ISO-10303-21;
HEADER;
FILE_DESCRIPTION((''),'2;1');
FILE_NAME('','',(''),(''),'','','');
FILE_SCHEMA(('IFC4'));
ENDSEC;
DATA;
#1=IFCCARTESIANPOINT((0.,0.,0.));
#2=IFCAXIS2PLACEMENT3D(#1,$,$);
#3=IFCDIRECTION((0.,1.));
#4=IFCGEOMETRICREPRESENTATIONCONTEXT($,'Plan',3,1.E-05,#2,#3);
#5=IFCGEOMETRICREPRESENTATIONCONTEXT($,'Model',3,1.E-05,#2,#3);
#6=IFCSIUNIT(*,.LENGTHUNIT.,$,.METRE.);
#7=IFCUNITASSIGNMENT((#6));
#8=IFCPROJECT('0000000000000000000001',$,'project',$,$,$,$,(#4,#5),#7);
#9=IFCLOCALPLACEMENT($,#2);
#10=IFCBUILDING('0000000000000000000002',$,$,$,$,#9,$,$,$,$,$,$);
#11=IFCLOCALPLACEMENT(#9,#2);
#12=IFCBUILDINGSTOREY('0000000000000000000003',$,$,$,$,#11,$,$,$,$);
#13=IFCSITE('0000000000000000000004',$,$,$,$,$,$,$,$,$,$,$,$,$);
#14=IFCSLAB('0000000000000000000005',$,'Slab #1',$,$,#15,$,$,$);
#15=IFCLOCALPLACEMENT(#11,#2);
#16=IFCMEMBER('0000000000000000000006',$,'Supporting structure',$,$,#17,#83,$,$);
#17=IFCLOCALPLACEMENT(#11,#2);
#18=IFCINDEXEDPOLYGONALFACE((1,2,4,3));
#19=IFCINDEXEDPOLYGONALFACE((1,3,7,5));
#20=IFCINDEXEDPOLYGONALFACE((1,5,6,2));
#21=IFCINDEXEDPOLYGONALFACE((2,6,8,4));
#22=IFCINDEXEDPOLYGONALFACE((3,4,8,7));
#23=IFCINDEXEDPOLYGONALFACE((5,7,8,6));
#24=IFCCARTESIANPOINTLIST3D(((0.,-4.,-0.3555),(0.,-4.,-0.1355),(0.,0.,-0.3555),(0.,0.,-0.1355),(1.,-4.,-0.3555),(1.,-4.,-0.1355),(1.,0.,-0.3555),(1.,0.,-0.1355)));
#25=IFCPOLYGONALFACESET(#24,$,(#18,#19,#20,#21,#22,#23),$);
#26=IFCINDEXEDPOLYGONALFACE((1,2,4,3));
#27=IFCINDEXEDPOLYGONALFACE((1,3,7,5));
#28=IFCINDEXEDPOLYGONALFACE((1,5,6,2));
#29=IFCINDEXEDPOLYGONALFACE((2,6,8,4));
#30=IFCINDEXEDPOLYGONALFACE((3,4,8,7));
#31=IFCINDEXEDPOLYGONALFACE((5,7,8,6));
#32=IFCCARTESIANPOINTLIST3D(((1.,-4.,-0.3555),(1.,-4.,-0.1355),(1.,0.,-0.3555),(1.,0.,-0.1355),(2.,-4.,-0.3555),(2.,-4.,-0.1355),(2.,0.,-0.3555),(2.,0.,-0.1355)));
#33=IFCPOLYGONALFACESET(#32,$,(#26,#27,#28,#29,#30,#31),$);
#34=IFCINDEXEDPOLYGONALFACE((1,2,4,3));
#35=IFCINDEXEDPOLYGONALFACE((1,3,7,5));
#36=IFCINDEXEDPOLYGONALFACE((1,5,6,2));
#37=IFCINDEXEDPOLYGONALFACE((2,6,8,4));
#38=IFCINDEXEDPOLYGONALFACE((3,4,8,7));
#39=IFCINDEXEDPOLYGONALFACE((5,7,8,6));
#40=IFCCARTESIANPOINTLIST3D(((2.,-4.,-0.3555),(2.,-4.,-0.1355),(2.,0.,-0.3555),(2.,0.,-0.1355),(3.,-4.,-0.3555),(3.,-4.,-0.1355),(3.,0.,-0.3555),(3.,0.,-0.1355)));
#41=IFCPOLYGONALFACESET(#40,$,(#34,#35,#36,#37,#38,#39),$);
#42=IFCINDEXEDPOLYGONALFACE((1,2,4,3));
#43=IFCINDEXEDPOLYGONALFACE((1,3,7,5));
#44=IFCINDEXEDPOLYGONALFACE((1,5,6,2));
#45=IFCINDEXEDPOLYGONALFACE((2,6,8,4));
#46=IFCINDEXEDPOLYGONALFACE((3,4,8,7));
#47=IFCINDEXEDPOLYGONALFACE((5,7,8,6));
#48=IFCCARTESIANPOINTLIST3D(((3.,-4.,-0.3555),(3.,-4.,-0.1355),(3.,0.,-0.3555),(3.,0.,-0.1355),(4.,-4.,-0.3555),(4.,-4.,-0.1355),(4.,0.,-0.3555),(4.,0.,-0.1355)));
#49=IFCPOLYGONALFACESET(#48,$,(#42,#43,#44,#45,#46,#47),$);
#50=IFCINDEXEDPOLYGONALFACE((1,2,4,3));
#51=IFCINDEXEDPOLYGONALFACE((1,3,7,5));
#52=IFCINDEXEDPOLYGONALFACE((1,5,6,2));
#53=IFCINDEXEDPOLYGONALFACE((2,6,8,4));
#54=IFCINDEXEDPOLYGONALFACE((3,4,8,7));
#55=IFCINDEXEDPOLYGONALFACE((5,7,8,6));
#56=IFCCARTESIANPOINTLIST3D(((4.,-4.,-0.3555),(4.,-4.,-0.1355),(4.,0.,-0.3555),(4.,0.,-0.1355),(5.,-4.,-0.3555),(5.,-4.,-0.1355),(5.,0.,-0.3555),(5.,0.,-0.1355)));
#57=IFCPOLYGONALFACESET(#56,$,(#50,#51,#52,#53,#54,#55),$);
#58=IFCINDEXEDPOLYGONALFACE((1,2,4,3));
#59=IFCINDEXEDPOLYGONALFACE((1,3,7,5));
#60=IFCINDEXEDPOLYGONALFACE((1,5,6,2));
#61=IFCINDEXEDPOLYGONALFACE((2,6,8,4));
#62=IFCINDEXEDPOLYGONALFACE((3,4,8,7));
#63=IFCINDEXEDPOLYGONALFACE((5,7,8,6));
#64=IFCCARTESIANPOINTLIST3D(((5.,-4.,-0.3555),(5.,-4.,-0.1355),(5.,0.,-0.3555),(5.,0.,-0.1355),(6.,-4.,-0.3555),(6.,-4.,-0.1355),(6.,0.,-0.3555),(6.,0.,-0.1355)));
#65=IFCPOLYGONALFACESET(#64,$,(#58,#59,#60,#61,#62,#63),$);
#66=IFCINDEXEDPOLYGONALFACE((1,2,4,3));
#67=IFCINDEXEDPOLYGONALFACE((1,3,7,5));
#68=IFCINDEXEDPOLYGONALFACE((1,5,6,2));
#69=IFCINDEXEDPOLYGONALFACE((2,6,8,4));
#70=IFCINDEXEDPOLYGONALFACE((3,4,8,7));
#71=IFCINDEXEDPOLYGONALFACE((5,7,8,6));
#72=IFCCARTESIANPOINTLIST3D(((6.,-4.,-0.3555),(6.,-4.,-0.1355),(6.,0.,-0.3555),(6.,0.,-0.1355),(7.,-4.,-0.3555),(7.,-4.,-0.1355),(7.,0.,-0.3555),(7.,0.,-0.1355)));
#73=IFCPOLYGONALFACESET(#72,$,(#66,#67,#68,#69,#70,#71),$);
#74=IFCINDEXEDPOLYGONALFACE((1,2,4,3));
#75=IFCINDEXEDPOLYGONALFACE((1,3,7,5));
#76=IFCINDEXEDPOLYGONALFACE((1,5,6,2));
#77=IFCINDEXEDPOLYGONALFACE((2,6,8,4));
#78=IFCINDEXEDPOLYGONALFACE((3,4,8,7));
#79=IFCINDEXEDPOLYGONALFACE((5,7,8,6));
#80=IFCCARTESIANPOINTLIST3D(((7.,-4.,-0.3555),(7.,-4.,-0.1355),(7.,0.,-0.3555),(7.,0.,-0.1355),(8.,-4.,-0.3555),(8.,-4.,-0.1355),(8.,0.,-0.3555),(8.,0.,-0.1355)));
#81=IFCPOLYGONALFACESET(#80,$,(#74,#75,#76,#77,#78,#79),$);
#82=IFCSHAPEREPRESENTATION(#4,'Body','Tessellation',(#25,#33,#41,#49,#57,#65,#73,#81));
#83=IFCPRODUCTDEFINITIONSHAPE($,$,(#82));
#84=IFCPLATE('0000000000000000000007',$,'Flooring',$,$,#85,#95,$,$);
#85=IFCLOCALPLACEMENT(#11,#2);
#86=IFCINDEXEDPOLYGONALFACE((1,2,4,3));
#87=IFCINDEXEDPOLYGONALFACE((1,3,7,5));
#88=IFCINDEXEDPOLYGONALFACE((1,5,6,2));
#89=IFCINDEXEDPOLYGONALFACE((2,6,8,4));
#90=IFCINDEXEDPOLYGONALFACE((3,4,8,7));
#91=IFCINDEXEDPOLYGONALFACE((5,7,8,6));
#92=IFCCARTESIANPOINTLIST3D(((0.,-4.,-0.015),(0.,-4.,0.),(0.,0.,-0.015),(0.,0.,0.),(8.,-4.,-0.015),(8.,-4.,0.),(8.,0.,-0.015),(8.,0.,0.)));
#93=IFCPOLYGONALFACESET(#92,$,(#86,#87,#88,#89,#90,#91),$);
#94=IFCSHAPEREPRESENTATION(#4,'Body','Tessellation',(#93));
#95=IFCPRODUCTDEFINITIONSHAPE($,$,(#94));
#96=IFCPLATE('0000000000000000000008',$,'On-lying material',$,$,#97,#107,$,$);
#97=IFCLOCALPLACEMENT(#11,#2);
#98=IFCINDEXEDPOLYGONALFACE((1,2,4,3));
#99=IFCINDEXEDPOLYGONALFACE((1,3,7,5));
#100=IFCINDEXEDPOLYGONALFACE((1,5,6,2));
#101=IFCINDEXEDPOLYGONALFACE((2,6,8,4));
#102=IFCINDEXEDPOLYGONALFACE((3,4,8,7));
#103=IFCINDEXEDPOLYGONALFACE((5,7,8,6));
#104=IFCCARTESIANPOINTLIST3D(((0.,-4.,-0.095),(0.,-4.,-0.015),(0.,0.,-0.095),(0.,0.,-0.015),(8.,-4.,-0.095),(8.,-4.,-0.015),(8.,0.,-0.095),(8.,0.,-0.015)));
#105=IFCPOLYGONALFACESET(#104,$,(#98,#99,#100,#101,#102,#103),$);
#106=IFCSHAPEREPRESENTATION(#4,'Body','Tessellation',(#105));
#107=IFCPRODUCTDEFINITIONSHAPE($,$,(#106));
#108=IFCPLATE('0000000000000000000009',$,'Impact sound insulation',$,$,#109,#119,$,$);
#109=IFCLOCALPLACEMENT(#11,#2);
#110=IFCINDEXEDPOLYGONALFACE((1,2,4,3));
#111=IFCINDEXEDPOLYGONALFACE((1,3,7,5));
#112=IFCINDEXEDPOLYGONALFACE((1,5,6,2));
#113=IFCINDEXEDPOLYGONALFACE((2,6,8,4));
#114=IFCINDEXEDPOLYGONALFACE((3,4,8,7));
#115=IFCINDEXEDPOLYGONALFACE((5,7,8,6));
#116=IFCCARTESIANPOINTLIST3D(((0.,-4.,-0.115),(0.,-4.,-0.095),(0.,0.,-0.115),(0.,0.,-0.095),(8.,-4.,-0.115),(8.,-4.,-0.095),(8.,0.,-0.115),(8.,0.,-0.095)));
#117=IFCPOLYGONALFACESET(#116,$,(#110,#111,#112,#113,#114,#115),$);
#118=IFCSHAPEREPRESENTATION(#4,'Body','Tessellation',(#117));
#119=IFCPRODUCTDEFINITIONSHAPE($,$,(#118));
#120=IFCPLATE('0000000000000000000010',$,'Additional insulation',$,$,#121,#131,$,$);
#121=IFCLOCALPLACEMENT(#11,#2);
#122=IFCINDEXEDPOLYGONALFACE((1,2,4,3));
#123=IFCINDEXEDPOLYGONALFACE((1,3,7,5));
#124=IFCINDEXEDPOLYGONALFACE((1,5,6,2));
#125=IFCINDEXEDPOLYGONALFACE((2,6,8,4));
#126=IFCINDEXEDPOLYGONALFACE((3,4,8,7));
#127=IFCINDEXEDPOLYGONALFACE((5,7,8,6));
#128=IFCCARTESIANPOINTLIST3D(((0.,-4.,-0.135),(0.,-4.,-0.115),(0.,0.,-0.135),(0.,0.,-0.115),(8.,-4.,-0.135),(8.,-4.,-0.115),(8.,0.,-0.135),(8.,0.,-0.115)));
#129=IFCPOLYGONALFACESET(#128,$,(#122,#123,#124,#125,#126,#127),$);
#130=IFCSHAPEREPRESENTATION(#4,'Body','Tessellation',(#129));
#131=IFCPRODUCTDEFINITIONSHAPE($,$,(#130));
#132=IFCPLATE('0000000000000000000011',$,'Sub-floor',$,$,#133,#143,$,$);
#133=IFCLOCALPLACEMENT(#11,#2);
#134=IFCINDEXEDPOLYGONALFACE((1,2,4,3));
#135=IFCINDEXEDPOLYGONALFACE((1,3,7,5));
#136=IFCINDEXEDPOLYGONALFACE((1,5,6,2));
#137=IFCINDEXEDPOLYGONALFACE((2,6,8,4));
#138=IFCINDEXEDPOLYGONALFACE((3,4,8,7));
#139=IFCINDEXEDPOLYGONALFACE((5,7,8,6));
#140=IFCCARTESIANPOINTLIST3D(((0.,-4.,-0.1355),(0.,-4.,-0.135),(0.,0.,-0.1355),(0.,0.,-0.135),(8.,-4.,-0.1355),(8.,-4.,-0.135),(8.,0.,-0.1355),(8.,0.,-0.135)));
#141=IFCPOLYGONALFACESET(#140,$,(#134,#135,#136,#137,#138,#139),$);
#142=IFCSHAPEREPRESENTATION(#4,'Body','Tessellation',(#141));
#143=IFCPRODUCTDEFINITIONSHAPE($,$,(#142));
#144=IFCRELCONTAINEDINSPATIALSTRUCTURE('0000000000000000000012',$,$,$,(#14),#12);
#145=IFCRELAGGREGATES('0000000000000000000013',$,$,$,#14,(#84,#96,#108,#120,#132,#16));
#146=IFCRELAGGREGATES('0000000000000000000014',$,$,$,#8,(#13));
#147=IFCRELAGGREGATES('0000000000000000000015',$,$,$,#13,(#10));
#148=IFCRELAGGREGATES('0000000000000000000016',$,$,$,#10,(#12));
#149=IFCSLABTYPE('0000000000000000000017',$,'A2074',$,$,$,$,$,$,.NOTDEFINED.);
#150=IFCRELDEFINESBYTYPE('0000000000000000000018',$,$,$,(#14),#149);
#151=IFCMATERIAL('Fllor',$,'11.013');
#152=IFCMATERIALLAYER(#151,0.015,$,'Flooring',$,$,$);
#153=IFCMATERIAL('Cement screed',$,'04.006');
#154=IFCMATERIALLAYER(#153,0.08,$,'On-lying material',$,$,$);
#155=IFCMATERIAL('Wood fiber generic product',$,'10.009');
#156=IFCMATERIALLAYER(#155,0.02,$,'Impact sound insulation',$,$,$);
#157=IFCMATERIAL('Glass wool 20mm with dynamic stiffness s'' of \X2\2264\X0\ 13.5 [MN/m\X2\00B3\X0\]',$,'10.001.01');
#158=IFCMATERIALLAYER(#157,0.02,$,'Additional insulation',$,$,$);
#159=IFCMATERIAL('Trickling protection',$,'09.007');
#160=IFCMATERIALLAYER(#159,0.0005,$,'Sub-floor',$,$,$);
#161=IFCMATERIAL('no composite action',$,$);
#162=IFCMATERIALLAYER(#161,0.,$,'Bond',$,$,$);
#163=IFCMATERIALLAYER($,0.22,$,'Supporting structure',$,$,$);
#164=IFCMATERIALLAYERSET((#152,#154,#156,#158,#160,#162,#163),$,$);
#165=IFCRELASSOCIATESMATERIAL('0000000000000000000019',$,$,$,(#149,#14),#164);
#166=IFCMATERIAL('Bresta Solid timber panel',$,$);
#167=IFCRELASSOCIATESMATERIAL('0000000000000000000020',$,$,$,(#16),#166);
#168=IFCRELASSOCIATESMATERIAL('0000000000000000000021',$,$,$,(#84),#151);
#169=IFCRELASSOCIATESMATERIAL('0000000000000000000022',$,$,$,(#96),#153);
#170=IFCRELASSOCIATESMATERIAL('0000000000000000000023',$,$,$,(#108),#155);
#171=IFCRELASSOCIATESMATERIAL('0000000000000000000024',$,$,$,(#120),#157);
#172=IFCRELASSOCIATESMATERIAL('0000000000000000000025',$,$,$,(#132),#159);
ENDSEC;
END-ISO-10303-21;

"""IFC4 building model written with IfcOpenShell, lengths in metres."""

from ifc_helpers import new_model, si_unit, direction, frame, frame_2d, origin, origin_with_axes, place, context, project, spatial, rectangle, extrude, material, layer, layer_set, type_object, element, aggregate, save


model = new_model("IFC4")

# Units and contexts
plan_context = context("Plan", 3, precision=1e-05, world=origin(), true_north=direction((0.0, 1.0)))
model_context = context("Model", 3, precision=1e-05, world=origin(), true_north=direction((0.0, 1.0)))
ifc_project = project(units=[si_unit("LENGTHUNIT", "METRE")], contexts=[plan_context, model_context])

# Site, building, storey
site = spatial("IfcSite", under=ifc_project)
building_placement = place(None, origin())
building = spatial("IfcBuilding", under=site, at=building_placement)
storey_placement = place(building_placement, origin())
storey = spatial("IfcBuildingStorey", under=building, at=storey_placement)

# Slab, member, plates
ifc_material_1 = material(Name="Fllor", Category="11.013")
ifc_layer_1 = layer(ifc_material_1, 0.015, Name="Flooring")
ifc_material_2 = material(Name="Cement screed", Category="04.006")
ifc_layer_2 = layer(ifc_material_2, 0.08, Name="On-lying material")
ifc_material_3 = material(Name="Wood fiber generic product", Category="10.009")
ifc_layer_3 = layer(ifc_material_3, 0.02, Name="Impact sound insulation")
ifc_material_4 = material(Name="Glass wool 20mm with dynamic stiffness s' of ≤ 13.5 [MN/m³]", Category="10.001.01")
ifc_layer_4 = layer(ifc_material_4, 0.02, Name="Additional insulation")
ifc_material_5 = material(Name="Trickling protection", Category="09.007")
ifc_layer_5 = layer(ifc_material_5, 0.0005, Name="Sub-floor")
ifc_material_6 = material(Name="no composite action")
ifc_layer_6 = layer(ifc_material_6, 0.0, Name="Bond")
ifc_layer_7 = layer(None, 0.22, Name="Supporting structure")
ifc_layer_set = layer_set([ifc_layer_1, ifc_layer_2, ifc_layer_3, ifc_layer_4, ifc_layer_5, ifc_layer_6, ifc_layer_7])
slab_type = type_object("IfcSlabType", Name="A2074", PredefinedType="NOTDEFINED", material=ifc_layer_set)
slab_placement = place(None, frame((0.0, 0.0, 0.0), z_axis=(0.0, 0.0, -1.0), x_axis=(1.0, 0.0, 0.0)))
slab = element("IfcSlab", 1, at=slab_placement, inside=storey, type_object=slab_type, material=ifc_layer_set, Name="Slab #1")
ifc_material_7 = material(Name="Bresta Solid timber panel")
member_placement = place(slab_placement, origin())
member = element("IfcMember", 2, at=member_placement, material=ifc_material_7, Name="Supporting structure", context=plan_context, shape_type="SweptSolid", body=[
    extrude(rectangle(XDim=1.0, YDim=0.22, at=frame_2d((0.5, 0.11), x_axis=(1.0, 0.0))), frame((0.0, 4.0, 0.1355), z_axis=(0.0, -1.0, 0.0), x_axis=(1.0, 0.0, 0.0)), (0.0, 0.0, 1.0), 4.0),
    extrude(rectangle(XDim=1.0, YDim=0.22, at=frame_2d((0.5, 0.11), x_axis=(1.0, 0.0))), frame((1.0, 4.0, 0.1355), z_axis=(0.0, -1.0, 0.0), x_axis=(1.0, 0.0, 0.0)), (0.0, 0.0, 1.0), 4.0),
    extrude(rectangle(XDim=1.0, YDim=0.22, at=frame_2d((0.5, 0.11), x_axis=(1.0, 0.0))), frame((2.0, 4.0, 0.1355), z_axis=(0.0, -1.0, 0.0), x_axis=(1.0, 0.0, 0.0)), (0.0, 0.0, 1.0), 4.0),
    extrude(rectangle(XDim=1.0, YDim=0.22, at=frame_2d((0.5, 0.11), x_axis=(1.0, 0.0))), frame((3.0, 4.0, 0.1355), z_axis=(0.0, -1.0, 0.0), x_axis=(1.0, 0.0, 0.0)), (0.0, 0.0, 1.0), 4.0),
    extrude(rectangle(XDim=1.0, YDim=0.22, at=frame_2d((0.5, 0.11), x_axis=(1.0, 0.0))), frame((4.0, 4.0, 0.1355), z_axis=(0.0, -1.0, 0.0), x_axis=(1.0, 0.0, 0.0)), (0.0, 0.0, 1.0), 4.0),
    extrude(rectangle(XDim=1.0, YDim=0.22, at=frame_2d((0.5, 0.11), x_axis=(1.0, 0.0))), frame((5.0, 4.0, 0.1355), z_axis=(0.0, -1.0, 0.0), x_axis=(1.0, 0.0, 0.0)), (0.0, 0.0, 1.0), 4.0),
    extrude(rectangle(XDim=1.0, YDim=0.22, at=frame_2d((0.5, 0.11), x_axis=(1.0, 0.0))), frame((6.0, 4.0, 0.1355), z_axis=(0.0, -1.0, 0.0), x_axis=(1.0, 0.0, 0.0)), (0.0, 0.0, 1.0), 4.0),
    extrude(rectangle(XDim=1.0, YDim=0.22, at=frame_2d((0.5, 0.11), x_axis=(1.0, 0.0))), frame((7.0, 4.0, 0.1355), z_axis=(0.0, -1.0, 0.0), x_axis=(1.0, 0.0, 0.0)), (0.0, 0.0, 1.0), 4.0),
])
plate_1_placement = place(slab_placement, origin())
plate_1 = element("IfcPlate", 3, at=plate_1_placement, material=ifc_material_1, Name="Flooring", context=plan_context, shape_type="SweptSolid", body=[
    extrude(rectangle(XDim=8.0, YDim=4.0, at=frame_2d((4.0, 2.0), x_axis=(1.0, 0.0))), origin_with_axes(), (0.0, 0.0, 1.0), 0.015),
])
plate_2_placement = place(slab_placement, origin())
plate_2 = element("IfcPlate", 4, at=plate_2_placement, material=ifc_material_2, Name="On-lying material", context=plan_context, shape_type="SweptSolid", body=[
    extrude(rectangle(XDim=8.0, YDim=4.0, at=frame_2d((4.0, 2.0), x_axis=(1.0, 0.0))), frame((0.0, 0.0, 0.015), z_axis=(0.0, 0.0, 1.0), x_axis=(1.0, 0.0, 0.0)), (0.0, 0.0, 1.0), 0.08),
])
plate_3_placement = place(slab_placement, origin())
plate_3 = element("IfcPlate", 5, at=plate_3_placement, material=ifc_material_3, Name="Impact sound insulation", context=plan_context, shape_type="SweptSolid", body=[
    extrude(rectangle(XDim=8.0, YDim=4.0, at=frame_2d((4.0, 2.0), x_axis=(1.0, 0.0))), frame((0.0, 0.0, 0.095), z_axis=(0.0, 0.0, 1.0), x_axis=(1.0, 0.0, 0.0)), (0.0, 0.0, 1.0), 0.02),
])
plate_4_placement = place(slab_placement, origin())
plate_4 = element("IfcPlate", 6, at=plate_4_placement, material=ifc_material_4, Name="Additional insulation", context=plan_context, shape_type="SweptSolid", body=[
    extrude(rectangle(XDim=8.0, YDim=4.0, at=frame_2d((4.0, 2.0), x_axis=(1.0, 0.0))), frame((0.0, 0.0, 0.115), z_axis=(0.0, 0.0, 1.0), x_axis=(1.0, 0.0, 0.0)), (0.0, 0.0, 1.0), 0.02),
])
plate_5_placement = place(slab_placement, origin())
plate_5 = element("IfcPlate", 7, at=plate_5_placement, material=ifc_material_5, Name="Sub-floor", context=plan_context, shape_type="SweptSolid", body=[
    extrude(rectangle(XDim=8.0, YDim=4.0, at=frame_2d((4.0, 2.0), x_axis=(1.0, 0.0))), frame((0.0, 0.0, 0.135), z_axis=(0.0, 0.0, 1.0), x_axis=(1.0, 0.0, 0.0)), (0.0, 0.0, 1.0), 0.0005),
])
aggregate(slab, [plate_1, plate_2, plate_3, plate_4, plate_5, member])

save(model, "model.ifc")
